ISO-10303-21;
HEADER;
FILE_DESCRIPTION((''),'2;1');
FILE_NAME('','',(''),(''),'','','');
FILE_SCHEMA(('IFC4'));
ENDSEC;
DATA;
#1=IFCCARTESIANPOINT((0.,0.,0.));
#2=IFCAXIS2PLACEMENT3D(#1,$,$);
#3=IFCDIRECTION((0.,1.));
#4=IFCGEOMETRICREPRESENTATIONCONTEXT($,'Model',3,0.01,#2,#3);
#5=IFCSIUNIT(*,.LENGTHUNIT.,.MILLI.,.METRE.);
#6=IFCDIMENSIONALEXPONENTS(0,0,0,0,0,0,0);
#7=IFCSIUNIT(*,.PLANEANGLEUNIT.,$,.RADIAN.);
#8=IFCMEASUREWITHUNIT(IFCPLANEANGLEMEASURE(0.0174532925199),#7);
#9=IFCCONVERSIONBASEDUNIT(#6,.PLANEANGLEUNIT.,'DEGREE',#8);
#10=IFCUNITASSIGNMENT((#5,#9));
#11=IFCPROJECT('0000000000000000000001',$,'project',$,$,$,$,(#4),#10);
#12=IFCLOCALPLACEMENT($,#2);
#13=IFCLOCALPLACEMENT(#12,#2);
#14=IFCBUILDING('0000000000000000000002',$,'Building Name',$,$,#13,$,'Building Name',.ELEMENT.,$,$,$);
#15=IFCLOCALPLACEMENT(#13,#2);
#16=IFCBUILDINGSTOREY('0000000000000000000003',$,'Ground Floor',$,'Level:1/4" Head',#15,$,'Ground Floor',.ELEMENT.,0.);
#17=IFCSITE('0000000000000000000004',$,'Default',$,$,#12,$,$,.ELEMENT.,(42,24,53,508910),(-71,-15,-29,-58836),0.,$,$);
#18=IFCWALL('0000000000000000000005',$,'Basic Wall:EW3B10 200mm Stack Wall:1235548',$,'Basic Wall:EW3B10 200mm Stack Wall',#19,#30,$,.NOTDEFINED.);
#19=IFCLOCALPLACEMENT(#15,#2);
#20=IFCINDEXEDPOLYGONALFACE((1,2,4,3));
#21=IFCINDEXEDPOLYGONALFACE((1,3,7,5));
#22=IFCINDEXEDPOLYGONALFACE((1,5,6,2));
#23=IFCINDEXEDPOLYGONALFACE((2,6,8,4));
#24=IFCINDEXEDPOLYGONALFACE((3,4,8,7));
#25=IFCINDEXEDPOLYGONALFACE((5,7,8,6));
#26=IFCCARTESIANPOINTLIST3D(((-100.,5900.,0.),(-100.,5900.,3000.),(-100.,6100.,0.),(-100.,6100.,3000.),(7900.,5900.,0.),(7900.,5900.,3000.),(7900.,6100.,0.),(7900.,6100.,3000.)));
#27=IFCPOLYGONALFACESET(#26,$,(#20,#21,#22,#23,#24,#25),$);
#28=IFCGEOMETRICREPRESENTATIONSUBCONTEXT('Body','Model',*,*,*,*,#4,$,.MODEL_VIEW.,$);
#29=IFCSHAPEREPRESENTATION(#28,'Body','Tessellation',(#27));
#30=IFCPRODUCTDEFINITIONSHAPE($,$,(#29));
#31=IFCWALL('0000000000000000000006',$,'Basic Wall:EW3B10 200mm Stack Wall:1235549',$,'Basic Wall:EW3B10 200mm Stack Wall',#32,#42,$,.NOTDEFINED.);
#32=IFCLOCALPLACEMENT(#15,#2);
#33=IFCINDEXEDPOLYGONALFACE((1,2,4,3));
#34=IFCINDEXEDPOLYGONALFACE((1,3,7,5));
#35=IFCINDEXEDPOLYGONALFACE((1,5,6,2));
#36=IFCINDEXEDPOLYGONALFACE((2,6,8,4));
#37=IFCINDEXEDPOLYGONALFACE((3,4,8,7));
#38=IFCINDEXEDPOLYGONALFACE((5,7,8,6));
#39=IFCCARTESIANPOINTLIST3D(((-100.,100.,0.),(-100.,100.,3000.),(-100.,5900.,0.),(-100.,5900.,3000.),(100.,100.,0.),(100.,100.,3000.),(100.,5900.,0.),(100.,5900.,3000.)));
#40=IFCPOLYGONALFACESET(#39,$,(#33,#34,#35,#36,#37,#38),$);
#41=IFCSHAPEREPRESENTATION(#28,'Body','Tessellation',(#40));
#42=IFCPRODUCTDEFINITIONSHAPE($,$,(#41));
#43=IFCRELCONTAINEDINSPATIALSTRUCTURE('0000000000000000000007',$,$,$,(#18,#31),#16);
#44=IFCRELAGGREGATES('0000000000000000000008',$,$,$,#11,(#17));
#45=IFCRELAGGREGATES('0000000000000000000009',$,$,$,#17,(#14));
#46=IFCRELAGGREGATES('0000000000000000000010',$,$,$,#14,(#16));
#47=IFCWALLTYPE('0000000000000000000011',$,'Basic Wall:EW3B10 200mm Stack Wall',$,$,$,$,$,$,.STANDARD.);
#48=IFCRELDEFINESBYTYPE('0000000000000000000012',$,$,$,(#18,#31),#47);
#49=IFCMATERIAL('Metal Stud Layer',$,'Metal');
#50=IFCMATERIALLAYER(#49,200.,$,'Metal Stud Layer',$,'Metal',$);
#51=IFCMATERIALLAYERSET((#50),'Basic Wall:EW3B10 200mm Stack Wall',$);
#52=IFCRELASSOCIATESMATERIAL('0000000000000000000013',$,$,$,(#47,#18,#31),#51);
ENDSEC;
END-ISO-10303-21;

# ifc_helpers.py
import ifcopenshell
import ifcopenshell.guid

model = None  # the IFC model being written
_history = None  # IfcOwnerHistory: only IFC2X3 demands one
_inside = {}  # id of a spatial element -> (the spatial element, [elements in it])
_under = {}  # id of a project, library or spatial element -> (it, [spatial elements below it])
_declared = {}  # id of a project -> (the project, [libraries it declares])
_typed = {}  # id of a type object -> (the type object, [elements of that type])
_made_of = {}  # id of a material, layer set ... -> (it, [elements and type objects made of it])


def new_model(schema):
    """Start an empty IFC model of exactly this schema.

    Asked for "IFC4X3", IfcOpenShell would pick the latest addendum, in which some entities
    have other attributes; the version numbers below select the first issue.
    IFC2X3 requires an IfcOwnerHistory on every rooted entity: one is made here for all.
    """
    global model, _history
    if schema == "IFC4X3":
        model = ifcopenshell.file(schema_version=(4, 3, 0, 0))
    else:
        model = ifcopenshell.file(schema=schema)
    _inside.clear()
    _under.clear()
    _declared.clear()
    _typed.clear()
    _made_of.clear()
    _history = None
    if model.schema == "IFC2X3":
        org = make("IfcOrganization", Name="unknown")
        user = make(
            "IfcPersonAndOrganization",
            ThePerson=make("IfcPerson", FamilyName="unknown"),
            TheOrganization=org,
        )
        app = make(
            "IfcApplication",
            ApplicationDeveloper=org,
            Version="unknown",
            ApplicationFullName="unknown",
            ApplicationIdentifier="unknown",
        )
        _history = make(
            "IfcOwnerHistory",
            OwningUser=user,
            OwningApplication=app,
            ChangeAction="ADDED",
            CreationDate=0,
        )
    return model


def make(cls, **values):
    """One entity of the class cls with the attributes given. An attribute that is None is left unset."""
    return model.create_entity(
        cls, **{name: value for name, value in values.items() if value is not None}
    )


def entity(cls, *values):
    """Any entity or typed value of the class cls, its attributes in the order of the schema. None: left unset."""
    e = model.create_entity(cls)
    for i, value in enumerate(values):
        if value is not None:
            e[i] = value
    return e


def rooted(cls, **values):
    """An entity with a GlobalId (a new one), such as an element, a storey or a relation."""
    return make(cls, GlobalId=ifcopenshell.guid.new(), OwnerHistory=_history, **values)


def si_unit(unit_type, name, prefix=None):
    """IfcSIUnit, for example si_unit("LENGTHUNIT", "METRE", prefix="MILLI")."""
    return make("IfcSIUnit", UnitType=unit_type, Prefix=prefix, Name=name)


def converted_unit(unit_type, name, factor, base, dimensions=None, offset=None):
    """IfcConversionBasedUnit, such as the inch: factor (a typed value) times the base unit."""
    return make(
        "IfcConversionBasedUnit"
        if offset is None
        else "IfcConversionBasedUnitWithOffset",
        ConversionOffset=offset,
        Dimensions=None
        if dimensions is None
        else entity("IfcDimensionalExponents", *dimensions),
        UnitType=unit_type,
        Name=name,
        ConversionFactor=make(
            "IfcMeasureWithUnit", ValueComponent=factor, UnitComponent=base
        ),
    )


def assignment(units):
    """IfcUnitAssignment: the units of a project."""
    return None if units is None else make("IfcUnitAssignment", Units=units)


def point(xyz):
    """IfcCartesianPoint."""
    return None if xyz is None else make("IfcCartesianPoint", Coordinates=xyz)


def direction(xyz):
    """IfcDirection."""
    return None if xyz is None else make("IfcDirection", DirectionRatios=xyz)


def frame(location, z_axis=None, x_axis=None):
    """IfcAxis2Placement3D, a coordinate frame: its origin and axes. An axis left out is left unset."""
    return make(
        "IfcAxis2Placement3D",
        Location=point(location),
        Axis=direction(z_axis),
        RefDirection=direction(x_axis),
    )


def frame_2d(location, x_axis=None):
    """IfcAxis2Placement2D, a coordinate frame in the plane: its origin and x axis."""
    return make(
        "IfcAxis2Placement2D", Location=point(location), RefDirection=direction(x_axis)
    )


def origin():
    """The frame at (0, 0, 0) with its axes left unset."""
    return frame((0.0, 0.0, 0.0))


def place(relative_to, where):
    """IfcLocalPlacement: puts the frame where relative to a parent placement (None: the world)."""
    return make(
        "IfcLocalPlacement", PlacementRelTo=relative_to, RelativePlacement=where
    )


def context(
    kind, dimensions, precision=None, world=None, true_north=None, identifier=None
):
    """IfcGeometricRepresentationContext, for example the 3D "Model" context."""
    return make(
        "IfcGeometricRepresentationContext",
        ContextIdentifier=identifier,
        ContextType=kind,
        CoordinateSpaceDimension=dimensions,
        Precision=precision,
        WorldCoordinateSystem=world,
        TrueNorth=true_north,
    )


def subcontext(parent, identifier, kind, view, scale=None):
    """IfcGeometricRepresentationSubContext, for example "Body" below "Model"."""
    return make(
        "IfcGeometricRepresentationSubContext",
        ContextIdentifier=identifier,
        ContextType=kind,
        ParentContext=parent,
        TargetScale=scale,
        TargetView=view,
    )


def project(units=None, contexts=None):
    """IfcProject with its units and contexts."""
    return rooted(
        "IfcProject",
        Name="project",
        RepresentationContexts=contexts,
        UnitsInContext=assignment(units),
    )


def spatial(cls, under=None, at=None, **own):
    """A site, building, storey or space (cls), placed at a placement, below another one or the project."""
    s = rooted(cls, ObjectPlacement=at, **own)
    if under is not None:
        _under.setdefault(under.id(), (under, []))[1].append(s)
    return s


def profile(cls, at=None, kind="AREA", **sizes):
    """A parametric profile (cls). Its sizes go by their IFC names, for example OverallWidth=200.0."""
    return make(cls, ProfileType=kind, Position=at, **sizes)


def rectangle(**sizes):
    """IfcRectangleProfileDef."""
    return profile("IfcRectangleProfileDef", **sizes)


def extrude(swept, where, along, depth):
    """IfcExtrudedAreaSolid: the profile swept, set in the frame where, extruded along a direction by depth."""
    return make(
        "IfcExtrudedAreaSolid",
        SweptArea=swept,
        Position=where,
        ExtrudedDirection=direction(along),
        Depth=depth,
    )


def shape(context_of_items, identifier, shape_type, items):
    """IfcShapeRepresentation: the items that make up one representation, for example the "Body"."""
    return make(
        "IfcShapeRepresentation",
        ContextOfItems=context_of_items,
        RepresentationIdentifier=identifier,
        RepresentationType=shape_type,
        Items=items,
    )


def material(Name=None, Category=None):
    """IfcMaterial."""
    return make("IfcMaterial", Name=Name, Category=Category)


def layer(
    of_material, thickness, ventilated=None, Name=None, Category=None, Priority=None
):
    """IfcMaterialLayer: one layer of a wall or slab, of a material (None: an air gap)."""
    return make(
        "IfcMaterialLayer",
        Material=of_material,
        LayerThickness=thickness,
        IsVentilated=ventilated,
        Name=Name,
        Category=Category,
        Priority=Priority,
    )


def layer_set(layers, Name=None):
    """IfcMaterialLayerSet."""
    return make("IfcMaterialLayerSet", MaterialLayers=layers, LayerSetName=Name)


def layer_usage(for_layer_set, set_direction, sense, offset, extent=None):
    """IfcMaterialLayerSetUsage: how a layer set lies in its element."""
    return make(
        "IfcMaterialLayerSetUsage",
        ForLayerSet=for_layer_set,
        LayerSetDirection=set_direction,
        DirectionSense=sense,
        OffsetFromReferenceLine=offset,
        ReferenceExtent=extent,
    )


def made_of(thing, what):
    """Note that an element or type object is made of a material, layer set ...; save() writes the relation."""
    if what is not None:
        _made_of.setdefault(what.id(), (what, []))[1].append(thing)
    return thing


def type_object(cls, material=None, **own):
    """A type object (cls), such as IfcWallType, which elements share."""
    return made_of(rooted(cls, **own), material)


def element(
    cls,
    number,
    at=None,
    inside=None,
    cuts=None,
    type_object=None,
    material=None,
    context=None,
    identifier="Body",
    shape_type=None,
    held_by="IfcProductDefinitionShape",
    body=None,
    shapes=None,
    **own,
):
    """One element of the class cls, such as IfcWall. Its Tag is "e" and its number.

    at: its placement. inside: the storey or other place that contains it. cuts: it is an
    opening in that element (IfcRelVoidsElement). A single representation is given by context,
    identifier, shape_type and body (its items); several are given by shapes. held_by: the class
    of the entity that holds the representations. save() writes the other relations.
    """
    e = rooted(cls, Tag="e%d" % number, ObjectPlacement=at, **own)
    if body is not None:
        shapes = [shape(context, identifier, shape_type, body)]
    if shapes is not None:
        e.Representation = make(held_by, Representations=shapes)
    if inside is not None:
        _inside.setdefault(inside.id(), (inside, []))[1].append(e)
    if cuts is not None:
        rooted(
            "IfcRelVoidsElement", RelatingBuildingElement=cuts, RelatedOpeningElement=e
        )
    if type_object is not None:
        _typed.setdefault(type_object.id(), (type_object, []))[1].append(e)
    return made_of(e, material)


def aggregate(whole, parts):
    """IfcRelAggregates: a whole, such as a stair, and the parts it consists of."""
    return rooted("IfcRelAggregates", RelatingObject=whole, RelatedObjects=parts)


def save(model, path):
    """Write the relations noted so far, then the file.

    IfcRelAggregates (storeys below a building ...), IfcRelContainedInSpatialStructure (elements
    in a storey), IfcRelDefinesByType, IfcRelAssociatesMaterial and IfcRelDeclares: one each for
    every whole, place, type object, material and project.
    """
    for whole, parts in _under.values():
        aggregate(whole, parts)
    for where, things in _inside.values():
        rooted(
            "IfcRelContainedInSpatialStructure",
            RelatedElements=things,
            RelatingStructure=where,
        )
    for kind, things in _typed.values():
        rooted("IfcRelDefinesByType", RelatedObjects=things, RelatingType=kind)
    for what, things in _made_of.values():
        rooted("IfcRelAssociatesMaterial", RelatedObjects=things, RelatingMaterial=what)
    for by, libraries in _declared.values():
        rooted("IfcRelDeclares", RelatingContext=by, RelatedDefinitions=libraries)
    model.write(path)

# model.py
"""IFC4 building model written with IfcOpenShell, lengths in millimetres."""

from ifc_helpers import new_model, entity, si_unit, converted_unit, direction, frame, frame_2d, origin, place, context, subcontext, project, spatial, rectangle, extrude, material, layer, layer_set, layer_usage, type_object, element, save


model = new_model("IFC4")

# Units and contexts
model_context = context("Model", 3, precision=0.01, world=origin(), true_north=direction((0.0, 1.0)))
body_context = subcontext(model_context, "Body", "Model", "MODEL_VIEW")
ifc_project = project(units=[si_unit("LENGTHUNIT", "METRE", prefix="MILLI"), converted_unit("PLANEANGLEUNIT", "DEGREE", entity("IfcPlaneAngleMeasure", 0.0174532925199), si_unit("PLANEANGLEUNIT", "RADIAN"), dimensions=[0, 0, 0, 0, 0, 0, 0])], contexts=[model_context])

# Site, building, storey
site_placement = place(None, origin())
site = spatial("IfcSite", under=ifc_project, at=site_placement, Name="Default", CompositionType="ELEMENT", RefLatitude=(42, 24, 53, 508910), RefLongitude=(-71, -15, -29, -58836), RefElevation=0.0)
building_placement = place(site_placement, origin())
building = spatial("IfcBuilding", under=site, at=building_placement, Name="Building Name", LongName="Building Name", CompositionType="ELEMENT")
storey_placement = place(building_placement, origin())
storey = spatial("IfcBuildingStorey", under=building, at=storey_placement, Name="Ground Floor", ObjectType="Level:1/4\" Head", LongName="Ground Floor", CompositionType="ELEMENT", Elevation=0.0)

# Shared definitions
ifc_material_1 = material(Name="Metal Stud Layer", Category="Metal")
ifc_layer_1 = layer(ifc_material_1, 200.0, Name="Metal Stud Layer", Category="Metal")
ifc_layer_set_1 = layer_set([ifc_layer_1], Name="Basic Wall:EW3B10 200mm Stack Wall")
wall_type = type_object("IfcWallType", Name="Basic Wall:EW3B10 200mm Stack Wall", PredefinedType="STANDARD", material=ifc_layer_set_1)

# Walls
ifc_layer_usage_1 = layer_usage(ifc_layer_set_1, "AXIS2", "NEGATIVE", 100.0)
wall_1_placement = place(storey_placement, frame((7900.0, 6000.0, 0.0), z_axis=(0.0, 0.0, 1.0), x_axis=(-1.0, 0.0, 0.0)))
element("IfcWall", 1, at=wall_1_placement, inside=storey, type_object=wall_type, material=ifc_layer_usage_1, Name="Basic Wall:EW3B10 200mm Stack Wall:1235548", ObjectType="Basic Wall:EW3B10 200mm Stack Wall", PredefinedType="NOTDEFINED", context=body_context, shape_type="SweptSolid", body=[
    extrude(rectangle(XDim=8000.0, YDim=200.0, at=frame_2d((4000.0, 0.0), x_axis=(-1.0, 0.0))), origin(), (0.0, 0.0, 1.0), 3000.0),
])
ifc_layer_usage_2 = layer_usage(ifc_layer_set_1, "AXIS2", "NEGATIVE", 100.0)
wall_2_placement = place(storey_placement, frame((0.0, 5900.0, 0.0), z_axis=(0.0, 0.0, 1.0), x_axis=(0.0, -1.0, 0.0)))
element("IfcWall", 2, at=wall_2_placement, inside=storey, type_object=wall_type, material=ifc_layer_usage_2, Name="Basic Wall:EW3B10 200mm Stack Wall:1235549", ObjectType="Basic Wall:EW3B10 200mm Stack Wall", PredefinedType="NOTDEFINED", context=body_context, shape_type="SweptSolid", body=[
    extrude(rectangle(XDim=5800.0, YDim=200.0, at=frame_2d((2900.0, 0.0), x_axis=(-1.0, 0.0))), origin(), (0.0, 0.0, 1.0), 3000.0),
])

save(model, "model.ifc")
